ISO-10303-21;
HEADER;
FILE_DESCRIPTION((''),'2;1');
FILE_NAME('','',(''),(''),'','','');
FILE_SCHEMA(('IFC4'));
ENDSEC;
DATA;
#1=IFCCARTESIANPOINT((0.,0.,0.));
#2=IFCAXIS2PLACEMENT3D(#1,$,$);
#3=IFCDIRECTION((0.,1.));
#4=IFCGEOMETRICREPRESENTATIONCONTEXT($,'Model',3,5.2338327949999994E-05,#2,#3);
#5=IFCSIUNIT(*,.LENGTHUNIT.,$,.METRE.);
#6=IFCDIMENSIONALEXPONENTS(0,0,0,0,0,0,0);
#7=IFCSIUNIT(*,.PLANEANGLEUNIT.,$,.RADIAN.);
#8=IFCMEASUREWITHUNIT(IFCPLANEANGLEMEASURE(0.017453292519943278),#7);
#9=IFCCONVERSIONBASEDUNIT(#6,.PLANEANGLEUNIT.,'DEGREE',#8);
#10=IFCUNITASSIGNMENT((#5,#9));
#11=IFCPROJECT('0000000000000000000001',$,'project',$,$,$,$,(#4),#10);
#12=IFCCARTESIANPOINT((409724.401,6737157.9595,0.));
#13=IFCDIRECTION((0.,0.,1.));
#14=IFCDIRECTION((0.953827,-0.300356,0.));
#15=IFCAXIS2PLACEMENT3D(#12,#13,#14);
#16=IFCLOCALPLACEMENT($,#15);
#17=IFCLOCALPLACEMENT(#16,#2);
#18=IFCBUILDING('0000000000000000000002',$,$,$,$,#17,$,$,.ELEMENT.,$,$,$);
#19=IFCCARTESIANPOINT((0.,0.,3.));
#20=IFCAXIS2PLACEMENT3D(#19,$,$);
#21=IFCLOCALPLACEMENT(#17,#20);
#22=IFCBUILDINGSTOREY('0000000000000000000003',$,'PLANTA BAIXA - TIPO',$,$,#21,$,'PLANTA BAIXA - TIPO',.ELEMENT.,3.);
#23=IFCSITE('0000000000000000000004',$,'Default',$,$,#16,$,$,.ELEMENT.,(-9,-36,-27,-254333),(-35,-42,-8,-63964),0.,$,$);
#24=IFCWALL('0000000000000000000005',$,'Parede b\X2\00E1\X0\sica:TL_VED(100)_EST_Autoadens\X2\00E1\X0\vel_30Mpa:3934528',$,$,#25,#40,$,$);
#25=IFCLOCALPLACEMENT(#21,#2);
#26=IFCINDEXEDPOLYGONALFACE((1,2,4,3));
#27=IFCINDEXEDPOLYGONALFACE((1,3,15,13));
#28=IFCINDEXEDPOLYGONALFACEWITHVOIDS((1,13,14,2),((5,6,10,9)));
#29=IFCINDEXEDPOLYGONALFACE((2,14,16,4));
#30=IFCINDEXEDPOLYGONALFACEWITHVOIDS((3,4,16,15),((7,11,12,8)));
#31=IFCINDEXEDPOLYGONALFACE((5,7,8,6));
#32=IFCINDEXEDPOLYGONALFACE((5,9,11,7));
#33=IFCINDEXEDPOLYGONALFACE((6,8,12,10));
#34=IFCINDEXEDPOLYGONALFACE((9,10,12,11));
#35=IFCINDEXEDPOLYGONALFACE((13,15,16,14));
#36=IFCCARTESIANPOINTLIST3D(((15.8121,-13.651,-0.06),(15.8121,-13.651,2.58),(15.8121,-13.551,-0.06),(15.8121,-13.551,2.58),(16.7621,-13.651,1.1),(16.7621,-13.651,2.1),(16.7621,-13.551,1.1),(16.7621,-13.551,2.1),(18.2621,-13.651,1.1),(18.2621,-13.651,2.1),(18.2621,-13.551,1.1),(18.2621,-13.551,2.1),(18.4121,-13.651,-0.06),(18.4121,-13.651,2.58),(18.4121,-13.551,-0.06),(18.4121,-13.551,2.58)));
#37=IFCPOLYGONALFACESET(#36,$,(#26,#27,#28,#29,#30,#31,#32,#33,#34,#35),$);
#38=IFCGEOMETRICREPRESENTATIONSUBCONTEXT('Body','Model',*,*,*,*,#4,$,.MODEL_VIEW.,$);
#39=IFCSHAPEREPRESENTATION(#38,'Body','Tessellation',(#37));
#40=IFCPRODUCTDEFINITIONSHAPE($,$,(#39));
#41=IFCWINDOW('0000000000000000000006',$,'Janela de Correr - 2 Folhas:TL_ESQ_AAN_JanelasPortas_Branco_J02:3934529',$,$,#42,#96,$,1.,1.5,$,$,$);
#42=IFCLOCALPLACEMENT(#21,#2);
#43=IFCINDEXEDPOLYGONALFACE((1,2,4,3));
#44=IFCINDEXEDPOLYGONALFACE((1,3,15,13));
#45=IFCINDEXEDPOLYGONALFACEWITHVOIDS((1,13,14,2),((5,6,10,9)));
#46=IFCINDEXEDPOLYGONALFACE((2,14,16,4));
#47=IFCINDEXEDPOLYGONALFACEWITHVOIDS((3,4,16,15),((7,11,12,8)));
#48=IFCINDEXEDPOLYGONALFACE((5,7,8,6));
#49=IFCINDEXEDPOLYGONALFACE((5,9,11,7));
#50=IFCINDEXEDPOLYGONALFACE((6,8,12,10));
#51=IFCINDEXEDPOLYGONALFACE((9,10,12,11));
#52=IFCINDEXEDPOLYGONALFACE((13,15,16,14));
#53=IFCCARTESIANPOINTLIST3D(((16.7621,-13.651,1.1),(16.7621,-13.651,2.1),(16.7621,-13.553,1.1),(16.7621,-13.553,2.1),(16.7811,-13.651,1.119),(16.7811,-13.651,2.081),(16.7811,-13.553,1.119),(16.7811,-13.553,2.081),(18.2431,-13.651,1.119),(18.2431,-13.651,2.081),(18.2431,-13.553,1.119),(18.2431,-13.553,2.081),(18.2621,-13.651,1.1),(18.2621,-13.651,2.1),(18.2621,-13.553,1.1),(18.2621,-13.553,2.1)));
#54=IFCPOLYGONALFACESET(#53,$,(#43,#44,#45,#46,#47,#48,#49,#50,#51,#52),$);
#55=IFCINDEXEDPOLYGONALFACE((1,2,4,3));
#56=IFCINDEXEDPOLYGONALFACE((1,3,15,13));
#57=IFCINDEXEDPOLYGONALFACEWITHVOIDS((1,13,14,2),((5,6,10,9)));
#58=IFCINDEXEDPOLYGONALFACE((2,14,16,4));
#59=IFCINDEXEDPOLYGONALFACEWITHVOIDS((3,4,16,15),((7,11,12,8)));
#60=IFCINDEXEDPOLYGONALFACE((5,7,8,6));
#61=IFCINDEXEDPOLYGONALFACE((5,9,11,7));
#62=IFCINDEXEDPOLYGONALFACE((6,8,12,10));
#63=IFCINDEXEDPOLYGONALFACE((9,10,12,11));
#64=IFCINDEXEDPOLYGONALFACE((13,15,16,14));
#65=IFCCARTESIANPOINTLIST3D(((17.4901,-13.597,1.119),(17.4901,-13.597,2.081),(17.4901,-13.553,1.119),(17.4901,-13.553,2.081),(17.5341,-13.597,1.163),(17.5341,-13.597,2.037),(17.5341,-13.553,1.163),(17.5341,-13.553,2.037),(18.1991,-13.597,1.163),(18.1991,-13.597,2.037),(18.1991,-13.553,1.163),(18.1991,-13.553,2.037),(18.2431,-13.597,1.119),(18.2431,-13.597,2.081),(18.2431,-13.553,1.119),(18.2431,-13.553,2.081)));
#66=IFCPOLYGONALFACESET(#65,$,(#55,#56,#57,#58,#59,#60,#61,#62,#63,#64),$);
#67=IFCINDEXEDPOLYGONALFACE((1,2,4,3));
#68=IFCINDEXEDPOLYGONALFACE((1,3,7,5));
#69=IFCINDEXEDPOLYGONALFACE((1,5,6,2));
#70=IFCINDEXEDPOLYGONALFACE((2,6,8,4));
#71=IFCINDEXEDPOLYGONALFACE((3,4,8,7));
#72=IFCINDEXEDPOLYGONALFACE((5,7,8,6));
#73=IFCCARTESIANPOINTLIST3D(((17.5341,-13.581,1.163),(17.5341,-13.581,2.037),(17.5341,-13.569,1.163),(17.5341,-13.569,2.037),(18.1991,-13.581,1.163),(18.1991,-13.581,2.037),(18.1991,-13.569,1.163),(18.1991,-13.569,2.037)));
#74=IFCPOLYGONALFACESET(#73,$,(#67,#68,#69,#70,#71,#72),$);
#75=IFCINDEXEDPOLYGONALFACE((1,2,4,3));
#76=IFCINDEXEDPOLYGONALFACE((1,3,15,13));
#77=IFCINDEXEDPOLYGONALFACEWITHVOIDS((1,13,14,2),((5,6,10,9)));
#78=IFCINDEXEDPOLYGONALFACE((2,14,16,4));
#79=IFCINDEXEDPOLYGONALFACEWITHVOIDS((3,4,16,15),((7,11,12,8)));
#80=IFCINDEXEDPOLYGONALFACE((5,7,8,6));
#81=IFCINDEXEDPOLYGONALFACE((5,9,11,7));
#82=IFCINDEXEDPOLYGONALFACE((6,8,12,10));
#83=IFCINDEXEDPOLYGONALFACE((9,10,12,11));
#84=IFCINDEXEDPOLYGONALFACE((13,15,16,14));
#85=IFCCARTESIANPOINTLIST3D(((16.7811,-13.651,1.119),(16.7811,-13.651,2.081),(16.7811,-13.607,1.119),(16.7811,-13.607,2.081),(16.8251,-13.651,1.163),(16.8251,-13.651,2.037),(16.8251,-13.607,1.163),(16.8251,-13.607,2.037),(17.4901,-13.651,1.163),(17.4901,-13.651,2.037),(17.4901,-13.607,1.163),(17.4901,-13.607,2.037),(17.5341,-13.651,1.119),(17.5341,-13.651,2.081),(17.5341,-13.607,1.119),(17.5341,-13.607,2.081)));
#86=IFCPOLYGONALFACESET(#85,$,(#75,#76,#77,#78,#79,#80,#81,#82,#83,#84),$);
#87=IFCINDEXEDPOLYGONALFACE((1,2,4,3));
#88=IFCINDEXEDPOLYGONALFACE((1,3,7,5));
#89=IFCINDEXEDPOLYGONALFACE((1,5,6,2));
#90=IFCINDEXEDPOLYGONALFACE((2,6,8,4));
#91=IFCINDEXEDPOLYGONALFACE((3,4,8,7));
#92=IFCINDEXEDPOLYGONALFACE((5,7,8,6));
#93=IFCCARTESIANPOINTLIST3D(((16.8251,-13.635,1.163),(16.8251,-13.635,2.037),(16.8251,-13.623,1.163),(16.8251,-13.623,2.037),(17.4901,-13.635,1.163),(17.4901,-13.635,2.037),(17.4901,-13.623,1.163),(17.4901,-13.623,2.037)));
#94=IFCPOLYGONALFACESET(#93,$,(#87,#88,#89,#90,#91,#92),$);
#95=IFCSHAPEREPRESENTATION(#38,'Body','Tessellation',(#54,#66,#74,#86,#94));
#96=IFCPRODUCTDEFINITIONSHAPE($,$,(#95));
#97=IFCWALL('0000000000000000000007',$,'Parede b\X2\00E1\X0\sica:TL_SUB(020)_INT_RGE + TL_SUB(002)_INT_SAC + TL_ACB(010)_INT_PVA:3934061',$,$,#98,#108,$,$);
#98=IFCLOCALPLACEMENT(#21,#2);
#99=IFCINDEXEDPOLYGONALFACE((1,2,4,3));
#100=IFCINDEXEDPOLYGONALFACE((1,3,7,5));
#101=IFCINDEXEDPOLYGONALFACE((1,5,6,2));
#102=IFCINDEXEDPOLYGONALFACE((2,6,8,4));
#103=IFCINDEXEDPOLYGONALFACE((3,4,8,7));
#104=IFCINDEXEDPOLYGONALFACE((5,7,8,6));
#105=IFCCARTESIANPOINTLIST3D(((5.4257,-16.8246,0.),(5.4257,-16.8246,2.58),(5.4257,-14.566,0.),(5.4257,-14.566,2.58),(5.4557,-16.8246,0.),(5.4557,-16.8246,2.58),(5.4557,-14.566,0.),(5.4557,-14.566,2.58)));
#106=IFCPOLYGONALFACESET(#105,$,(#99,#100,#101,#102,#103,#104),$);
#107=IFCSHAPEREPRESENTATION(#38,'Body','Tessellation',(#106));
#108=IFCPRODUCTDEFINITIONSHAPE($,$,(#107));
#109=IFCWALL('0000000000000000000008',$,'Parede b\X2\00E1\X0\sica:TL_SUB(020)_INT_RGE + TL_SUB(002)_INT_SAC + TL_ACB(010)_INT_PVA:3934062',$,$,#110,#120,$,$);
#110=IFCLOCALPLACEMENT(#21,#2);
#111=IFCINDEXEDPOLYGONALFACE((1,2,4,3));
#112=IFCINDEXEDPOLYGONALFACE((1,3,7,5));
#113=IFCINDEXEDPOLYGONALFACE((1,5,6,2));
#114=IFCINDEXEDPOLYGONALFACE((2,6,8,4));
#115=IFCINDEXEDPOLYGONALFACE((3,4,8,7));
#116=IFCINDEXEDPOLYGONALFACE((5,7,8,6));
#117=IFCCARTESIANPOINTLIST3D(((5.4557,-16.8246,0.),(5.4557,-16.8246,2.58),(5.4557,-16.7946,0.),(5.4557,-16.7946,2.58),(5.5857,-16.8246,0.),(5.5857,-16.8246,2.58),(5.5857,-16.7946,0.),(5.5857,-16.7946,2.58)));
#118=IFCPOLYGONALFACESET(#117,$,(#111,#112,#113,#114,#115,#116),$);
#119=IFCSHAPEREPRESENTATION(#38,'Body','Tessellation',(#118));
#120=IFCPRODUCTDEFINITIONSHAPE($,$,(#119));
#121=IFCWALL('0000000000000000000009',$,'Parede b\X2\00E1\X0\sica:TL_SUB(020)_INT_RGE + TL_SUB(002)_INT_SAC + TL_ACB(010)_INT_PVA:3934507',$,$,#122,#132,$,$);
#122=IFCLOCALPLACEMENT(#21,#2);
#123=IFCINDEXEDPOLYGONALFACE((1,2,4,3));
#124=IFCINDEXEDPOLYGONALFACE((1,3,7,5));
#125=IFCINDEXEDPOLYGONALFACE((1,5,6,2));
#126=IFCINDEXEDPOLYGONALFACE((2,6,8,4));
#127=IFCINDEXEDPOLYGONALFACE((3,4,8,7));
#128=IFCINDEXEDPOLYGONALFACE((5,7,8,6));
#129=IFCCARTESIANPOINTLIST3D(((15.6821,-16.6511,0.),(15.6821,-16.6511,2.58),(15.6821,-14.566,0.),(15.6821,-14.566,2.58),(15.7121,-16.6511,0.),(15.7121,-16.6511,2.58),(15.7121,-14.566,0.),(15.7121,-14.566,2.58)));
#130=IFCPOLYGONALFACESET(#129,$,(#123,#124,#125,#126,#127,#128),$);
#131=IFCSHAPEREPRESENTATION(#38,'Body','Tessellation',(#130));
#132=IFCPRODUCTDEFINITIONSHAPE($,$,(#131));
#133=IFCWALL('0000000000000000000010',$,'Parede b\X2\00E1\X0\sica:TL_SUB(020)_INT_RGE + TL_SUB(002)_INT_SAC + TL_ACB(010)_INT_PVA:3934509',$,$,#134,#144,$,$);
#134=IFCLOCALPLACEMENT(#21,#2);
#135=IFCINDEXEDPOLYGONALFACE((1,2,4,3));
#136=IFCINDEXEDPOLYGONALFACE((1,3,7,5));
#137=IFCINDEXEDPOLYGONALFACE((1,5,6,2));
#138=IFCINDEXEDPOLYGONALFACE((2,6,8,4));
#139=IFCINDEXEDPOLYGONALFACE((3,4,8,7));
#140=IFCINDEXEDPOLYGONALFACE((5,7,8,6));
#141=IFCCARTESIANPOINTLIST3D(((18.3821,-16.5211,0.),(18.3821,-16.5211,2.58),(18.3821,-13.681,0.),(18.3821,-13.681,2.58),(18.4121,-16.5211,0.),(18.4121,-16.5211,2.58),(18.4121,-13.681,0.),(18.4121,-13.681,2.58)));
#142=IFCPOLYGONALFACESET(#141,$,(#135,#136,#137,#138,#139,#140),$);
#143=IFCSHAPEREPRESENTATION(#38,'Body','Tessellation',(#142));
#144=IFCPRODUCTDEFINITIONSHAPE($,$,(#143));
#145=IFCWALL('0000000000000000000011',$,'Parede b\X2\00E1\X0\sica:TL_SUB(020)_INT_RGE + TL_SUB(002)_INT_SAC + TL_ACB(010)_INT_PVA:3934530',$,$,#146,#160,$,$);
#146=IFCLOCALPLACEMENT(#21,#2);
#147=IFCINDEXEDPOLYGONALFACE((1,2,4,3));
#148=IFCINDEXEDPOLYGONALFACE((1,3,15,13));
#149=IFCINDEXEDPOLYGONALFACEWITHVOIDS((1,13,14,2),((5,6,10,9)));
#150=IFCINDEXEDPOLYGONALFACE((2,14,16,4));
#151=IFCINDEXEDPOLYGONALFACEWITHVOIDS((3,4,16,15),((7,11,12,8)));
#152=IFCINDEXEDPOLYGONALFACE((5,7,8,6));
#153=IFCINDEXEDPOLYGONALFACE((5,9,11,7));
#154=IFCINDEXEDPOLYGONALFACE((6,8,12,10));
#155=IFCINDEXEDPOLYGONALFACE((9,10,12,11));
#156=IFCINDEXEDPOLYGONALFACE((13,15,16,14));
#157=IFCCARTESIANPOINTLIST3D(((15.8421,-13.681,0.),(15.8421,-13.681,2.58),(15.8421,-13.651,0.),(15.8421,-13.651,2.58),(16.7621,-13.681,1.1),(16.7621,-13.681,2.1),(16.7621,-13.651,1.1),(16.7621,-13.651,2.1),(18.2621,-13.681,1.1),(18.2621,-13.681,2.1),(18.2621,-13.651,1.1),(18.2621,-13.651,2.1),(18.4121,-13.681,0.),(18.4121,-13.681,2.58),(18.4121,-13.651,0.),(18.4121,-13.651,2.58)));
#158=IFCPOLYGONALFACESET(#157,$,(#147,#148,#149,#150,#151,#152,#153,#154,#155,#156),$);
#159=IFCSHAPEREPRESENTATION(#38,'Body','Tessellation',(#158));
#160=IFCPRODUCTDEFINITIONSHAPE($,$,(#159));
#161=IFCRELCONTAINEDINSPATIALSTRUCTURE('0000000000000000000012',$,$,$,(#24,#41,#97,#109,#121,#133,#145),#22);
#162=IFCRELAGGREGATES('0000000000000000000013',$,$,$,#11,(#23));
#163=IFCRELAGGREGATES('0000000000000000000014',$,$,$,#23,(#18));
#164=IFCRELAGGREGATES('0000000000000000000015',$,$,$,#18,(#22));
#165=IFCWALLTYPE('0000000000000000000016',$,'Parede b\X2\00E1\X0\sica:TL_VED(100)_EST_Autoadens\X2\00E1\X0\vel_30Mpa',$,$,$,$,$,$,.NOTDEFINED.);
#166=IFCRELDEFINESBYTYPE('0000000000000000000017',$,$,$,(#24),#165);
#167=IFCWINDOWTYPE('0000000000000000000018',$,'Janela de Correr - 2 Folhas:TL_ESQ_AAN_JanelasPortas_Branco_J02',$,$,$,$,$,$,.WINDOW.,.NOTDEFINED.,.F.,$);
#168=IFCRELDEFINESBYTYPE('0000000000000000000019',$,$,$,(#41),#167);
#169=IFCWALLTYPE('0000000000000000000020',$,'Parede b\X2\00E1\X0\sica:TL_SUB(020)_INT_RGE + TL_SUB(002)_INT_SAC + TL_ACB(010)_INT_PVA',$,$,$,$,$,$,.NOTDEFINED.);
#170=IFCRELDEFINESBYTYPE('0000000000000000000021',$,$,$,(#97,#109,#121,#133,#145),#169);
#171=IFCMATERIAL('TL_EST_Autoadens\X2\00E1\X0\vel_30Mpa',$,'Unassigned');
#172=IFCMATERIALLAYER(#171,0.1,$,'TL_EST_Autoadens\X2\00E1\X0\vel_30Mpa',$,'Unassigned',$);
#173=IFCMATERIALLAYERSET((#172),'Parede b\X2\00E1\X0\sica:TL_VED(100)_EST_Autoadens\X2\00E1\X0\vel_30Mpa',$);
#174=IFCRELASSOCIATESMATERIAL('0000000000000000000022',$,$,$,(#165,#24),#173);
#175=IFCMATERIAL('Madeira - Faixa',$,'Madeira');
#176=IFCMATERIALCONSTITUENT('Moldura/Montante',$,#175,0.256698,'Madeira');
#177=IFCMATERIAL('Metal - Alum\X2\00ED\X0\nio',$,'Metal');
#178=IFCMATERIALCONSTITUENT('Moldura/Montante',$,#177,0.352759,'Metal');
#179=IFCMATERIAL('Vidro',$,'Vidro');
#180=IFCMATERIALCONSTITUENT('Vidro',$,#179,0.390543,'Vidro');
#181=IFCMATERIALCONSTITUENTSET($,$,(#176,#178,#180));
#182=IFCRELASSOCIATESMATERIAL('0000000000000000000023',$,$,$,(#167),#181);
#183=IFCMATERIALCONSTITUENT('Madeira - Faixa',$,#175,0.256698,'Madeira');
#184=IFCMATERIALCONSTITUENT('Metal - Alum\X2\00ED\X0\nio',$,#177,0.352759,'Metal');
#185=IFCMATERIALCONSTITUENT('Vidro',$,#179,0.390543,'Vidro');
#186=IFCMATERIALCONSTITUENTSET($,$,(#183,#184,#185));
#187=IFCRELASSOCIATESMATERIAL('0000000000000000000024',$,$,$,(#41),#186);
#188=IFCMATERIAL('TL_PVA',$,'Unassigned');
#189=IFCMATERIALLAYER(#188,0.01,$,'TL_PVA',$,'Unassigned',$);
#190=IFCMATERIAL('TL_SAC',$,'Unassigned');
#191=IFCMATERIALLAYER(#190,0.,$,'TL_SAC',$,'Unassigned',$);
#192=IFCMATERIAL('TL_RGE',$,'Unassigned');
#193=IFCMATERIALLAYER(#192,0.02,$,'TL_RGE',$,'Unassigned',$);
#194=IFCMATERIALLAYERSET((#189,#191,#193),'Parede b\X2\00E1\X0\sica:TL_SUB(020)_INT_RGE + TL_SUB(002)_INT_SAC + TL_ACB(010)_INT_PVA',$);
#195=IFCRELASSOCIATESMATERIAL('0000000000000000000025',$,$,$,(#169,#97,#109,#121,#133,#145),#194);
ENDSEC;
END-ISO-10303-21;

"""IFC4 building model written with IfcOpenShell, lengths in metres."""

from ifc_helpers import new_model, entity, si_unit, converted_unit, direction, frame, frame_2d, origin, origin_2d_with_axis, place, context, subcontext, project, spatial, polyline, rectangle, outline, extrude, source, transform, mapped, material, layer, layer_set, layer_usage, constituent, constituent_set, type_object, type_shapes, element, fill, save


model = new_model("IFC4")

# Units and contexts
model_context = context("Model", 3, precision=5.2338327949999994e-05, world=origin(), true_north=direction((0.0, 1.0)))
body_context = subcontext(model_context, "Body", "Model", "MODEL_VIEW")
ifc_project = project(units=[si_unit("LENGTHUNIT", "METRE"), converted_unit("PLANEANGLEUNIT", "DEGREE", entity("IfcPlaneAngleMeasure", 0.017453292519943278), si_unit("PLANEANGLEUNIT", "RADIAN"), dimensions=[0, 0, 0, 0, 0, 0, 0])], contexts=[model_context])

# Site, building, storey
site_placement = place(None, frame((409724.401, 6737157.9595, 0.0), z_axis=(0.0, 0.0, 1.0), x_axis=(0.953827, -0.300356, 0.0)))
site = spatial("IfcSite", under=ifc_project, at=site_placement, Name="Default", CompositionType="ELEMENT", RefLatitude=(-9, -36, -27, -254333), RefLongitude=(-35, -42, -8, -63964), RefElevation=0.0)
building_placement = place(site_placement, origin())
building = spatial("IfcBuilding", under=site, at=building_placement, CompositionType="ELEMENT")
storey_placement = place(building_placement, frame((0.0, 0.0, 3.0)))
storey = spatial("IfcBuildingStorey", under=building, at=storey_placement, Name="PLANTA BAIXA - TIPO", LongName="PLANTA BAIXA - TIPO", CompositionType="ELEMENT", Elevation=3.0)

# Shared definitions
ifc_material_1 = material(Name="TL_EST_Autoadensável_30Mpa", Category="Unassigned")
ifc_layer_1 = layer(ifc_material_1, 0.1, Name="TL_EST_Autoadensável_30Mpa", Category="Unassigned")
ifc_layer_set_1 = layer_set([ifc_layer_1], Name="Parede básica:TL_VED(100)_EST_Autoadensável_30Mpa")
wall_type_1 = type_object("IfcWallType", Name="Parede básica:TL_VED(100)_EST_Autoadensável_30Mpa", PredefinedType="NOTDEFINED", material=ifc_layer_set_1)

# Shared definitions
ifc_material_2 = material(Name="Vidro", Category="Vidro")

# Wall, opening, window
ifc_layer_usage_1 = layer_usage(ifc_layer_set_1, "AXIS2", "POSITIVE", -0.05)
wall_1_placement = place(storey_placement, frame((18.4121, -13.601, -0.06), z_axis=(0.0, 0.0, 1.0), x_axis=(-1.0, 0.0, 0.0)))
wall_1 = element("IfcWall", 1, at=wall_1_placement, inside=storey, type_object=wall_type_1, material=ifc_layer_usage_1, Name="Parede básica:TL_VED(100)_EST_Autoadensável_30Mpa:3934528", context=body_context, shape_type="SweptSolid", body=[
    extrude(rectangle(XDim=2.6, YDim=0.1, at=frame_2d((1.3, 0.0), x_axis=(-1.0, 0.0))), origin(), (0.0, 0.0, 1.0), 2.64),
])
opening_1_placement = place(wall_1_placement, frame((1.65, 0.05, 1.16)))
opening_1 = element("IfcOpeningElement", 2, at=opening_1_placement, cuts=wall_1, PredefinedType="OPENING", context=body_context, shape_type="SweptSolid", body=[
    extrude(rectangle(XDim=1.0, YDim=1.5, at=frame_2d((0.5, 0.75), x_axis=(-1.0, 0.0))), frame((0.0, 0.0, 0.0), z_axis=(0.0, -1.0, 0.0), x_axis=(0.0, 0.0, 1.0)), (0.0, 0.0, 1.0), 0.1),
])
ifc_material_3 = material(Name="Madeira - Faixa", Category="Madeira")
ifc_constituent_1 = constituent(ifc_material_3, Name="Madeira - Faixa", Category="Madeira", fraction=0.256698)
ifc_material_4 = material(Name="Metal - Alumínio", Category="Metal")
ifc_constituent_2 = constituent(ifc_material_4, Name="Metal - Alumínio", Category="Metal", fraction=0.352759)
ifc_constituent_3 = constituent(ifc_material_2, Name="Vidro", Category="Vidro", fraction=0.390543)
ifc_constituent_set_1 = constituent_set(constituents=[ifc_constituent_1, ifc_constituent_2, ifc_constituent_3])
ifc_constituent_4 = constituent(ifc_material_3, Name="Moldura/Montante", Category="Madeira", fraction=0.256698)
ifc_constituent_5 = constituent(ifc_material_4, Name="Moldura/Montante", Category="Metal", fraction=0.352759)
ifc_constituent_6 = constituent(ifc_material_2, Name="Vidro", Category="Vidro", fraction=0.390543)
ifc_constituent_set_2 = constituent_set(constituents=[ifc_constituent_4, ifc_constituent_5, ifc_constituent_6])
window_type = type_object("IfcWindowType", Name="Janela de Correr - 2 Folhas:TL_ESQ_AAN_JanelasPortas_Branco_J02", ParameterTakesPrecedence=False, PartitioningType="NOTDEFINED", PredefinedType="WINDOW", material=ifc_constituent_set_2)
shared_shape_1 = source(origin(), body_context, "Body", "SweptSolid", [
    extrude(outline(polyline([(-0.75, -0.5), (0.75, -0.5), (0.75, 0.5), (-0.75, 0.5), (-0.75, -0.5)]), holes=[polyline([(-0.731, -0.481), (-0.731, 0.481), (0.731, 0.481), (0.731, -0.481), (-0.731, -0.481)])]), frame((0.75, 0.0, 0.5), z_axis=(0.0, 1.0, 0.0), x_axis=(1.0, 0.0, 0.0)), (0.0, 0.0, 1.0), 0.098),
    extrude(outline(polyline([(-0.3765, -0.481), (0.3765, -0.481), (0.3765, 0.481), (-0.3765, 0.481), (-0.3765, -0.481)]), holes=[polyline([(-0.3325, -0.437), (-0.3325, 0.437), (0.3325, 0.437), (0.3325, -0.437), (-0.3325, -0.437)])]), frame((1.1045, 0.054, 0.5), z_axis=(0.0, 1.0, 0.0), x_axis=(1.0, 0.0, 0.0)), (0.0, 0.0, 1.0), 0.044),
    extrude(rectangle(XDim=0.012, YDim=0.665, at=origin_2d_with_axis()), frame((1.1045, 0.076, 0.063), z_axis=(0.0, 0.0, 1.0), x_axis=(0.0, -1.0, 0.0)), (0.0, 0.0, 1.0), 0.874),
    extrude(outline(polyline([(-0.481, -0.3765), (0.481, -0.3765), (0.481, 0.3765), (-0.481, 0.3765), (-0.481, -0.3765)]), holes=[polyline([(-0.437, -0.3325), (-0.437, 0.3325), (0.437, 0.3325), (0.437, -0.3325), (-0.437, -0.3325)])]), frame((0.3955, 0.0, 0.5), z_axis=(0.0, 1.0, 0.0), x_axis=(0.0, 0.0, -1.0)), (0.0, 0.0, 1.0), 0.044),
    extrude(rectangle(XDim=0.012, YDim=0.665, at=origin_2d_with_axis()), frame((0.3955, 0.022, 0.063), z_axis=(0.0, 0.0, 1.0), x_axis=(0.0, -1.0, 0.0)), (0.0, 0.0, 1.0), 0.874),
])
type_shapes(window_type, [shared_shape_1])
window_placement = place(opening_1_placement, frame((0.0, 0.0, 0.0), z_axis=(0.0, 0.0, 1.0), x_axis=(-1.0, 0.0, 0.0)))
window = element("IfcWindow", 3, at=window_placement, inside=storey, type_object=window_type, material=ifc_constituent_set_1, Name="Janela de Correr - 2 Folhas:TL_ESQ_AAN_JanelasPortas_Branco_J02:3934529", OverallHeight=1.0, OverallWidth=1.5, context=body_context, shape_type="MappedRepresentation", body=[
    mapped(shared_shape_1, transform((0.0, 0.0, 0.0), scale=1.0)),
])
fill(opening_1, window)

# Walls
ifc_material_5 = material(Name="TL_PVA", Category="Unassigned")
ifc_layer_2 = layer(ifc_material_5, 0.01, Name="TL_PVA", Category="Unassigned")
ifc_material_6 = material(Name="TL_SAC", Category="Unassigned")
ifc_layer_3 = layer(ifc_material_6, 0.0, Name="TL_SAC", Category="Unassigned")
ifc_material_7 = material(Name="TL_RGE", Category="Unassigned")
ifc_layer_4 = layer(ifc_material_7, 0.02, Name="TL_RGE", Category="Unassigned")
ifc_layer_set_2 = layer_set([ifc_layer_2, ifc_layer_3, ifc_layer_4], Name="Parede básica:TL_SUB(020)_INT_RGE + TL_SUB(002)_INT_SAC + TL_ACB(010)_INT_PVA")
ifc_layer_usage_2 = layer_usage(ifc_layer_set_2, "AXIS2", "NEGATIVE", 0.015)
wall_type_2 = type_object("IfcWallType", Name="Parede básica:TL_SUB(020)_INT_RGE + TL_SUB(002)_INT_SAC + TL_ACB(010)_INT_PVA", PredefinedType="NOTDEFINED", material=ifc_layer_set_2)
wall_2_placement = place(storey_placement, frame((5.4407, -16.8246, 0.0), z_axis=(0.0, 0.0, 1.0), x_axis=(0.0, 1.0, 0.0)))
element("IfcWall", 4, at=wall_2_placement, inside=storey, type_object=wall_type_2, material=ifc_layer_usage_2, Name="Parede básica:TL_SUB(020)_INT_RGE + TL_SUB(002)_INT_SAC + TL_ACB(010)_INT_PVA:3934061", context=body_context, shape_type="SweptSolid", body=[
    extrude(rectangle(XDim=2.2587, YDim=0.03, at=frame_2d((1.1293, 0.0), x_axis=(-1.0, 0.0))), origin(), (0.0, 0.0, 1.0), 2.58),
])
ifc_layer_usage_3 = layer_usage(ifc_layer_set_2, "AXIS2", "NEGATIVE", 0.015)
wall_3_placement = place(storey_placement, frame((5.5857, -16.8096, 0.0), z_axis=(0.0, 0.0, 1.0), x_axis=(-1.0, 0.0, 0.0)))
element("IfcWall", 5, at=wall_3_placement, inside=storey, type_object=wall_type_2, material=ifc_layer_usage_3, Name="Parede básica:TL_SUB(020)_INT_RGE + TL_SUB(002)_INT_SAC + TL_ACB(010)_INT_PVA:3934062", context=body_context, shape_type="SweptSolid", body=[
    extrude(rectangle(XDim=0.13, YDim=0.03, at=frame_2d((0.065, 0.0), x_axis=(-1.0, 0.0))), origin(), (0.0, 0.0, 1.0), 2.58),
])
ifc_layer_usage_4 = layer_usage(ifc_layer_set_2, "AXIS2", "POSITIVE", -0.015)
wall_4_placement = place(storey_placement, frame((15.6971, -14.566, 0.0), z_axis=(0.0, 0.0, 1.0), x_axis=(0.0, -1.0, 0.0)))
element("IfcWall", 6, at=wall_4_placement, inside=storey, type_object=wall_type_2, material=ifc_layer_usage_4, Name="Parede básica:TL_SUB(020)_INT_RGE + TL_SUB(002)_INT_SAC + TL_ACB(010)_INT_PVA:3934507", context=body_context, shape_type="SweptSolid", body=[
    extrude(rectangle(XDim=2.0851, YDim=0.03, at=frame_2d((1.0426, 0.0), x_axis=(-1.0, 0.0))), origin(), (0.0, 0.0, 1.0), 2.58),
])
ifc_layer_usage_5 = layer_usage(ifc_layer_set_2, "AXIS2", "POSITIVE", -0.015)
wall_5_placement = place(storey_placement, frame((18.3971, -13.681, 0.0), z_axis=(0.0, 0.0, 1.0), x_axis=(0.0, -1.0, 0.0)))
element("IfcWall", 7, at=wall_5_placement, inside=storey, type_object=wall_type_2, material=ifc_layer_usage_5, Name="Parede básica:TL_SUB(020)_INT_RGE + TL_SUB(002)_INT_SAC + TL_ACB(010)_INT_PVA:3934509", context=body_context, shape_type="SweptSolid", body=[
    extrude(rectangle(XDim=2.8401, YDim=0.03, at=frame_2d((1.4201, 0.0), x_axis=(-1.0, 0.0))), origin(), (0.0, 0.0, 1.0), 2.58),
])

# Wall, opening
ifc_layer_usage_6 = layer_usage(ifc_layer_set_2, "AXIS2", "POSITIVE", -0.015)
wall_6_placement = place(storey_placement, frame((15.8421, -13.666, 0.0)))
wall_6 = element("IfcWall", 8, at=wall_6_placement, inside=storey, type_object=wall_type_2, material=ifc_layer_usage_6, Name="Parede básica:TL_SUB(020)_INT_RGE + TL_SUB(002)_INT_SAC + TL_ACB(010)_INT_PVA:3934530", context=body_context, shape_type="SweptSolid", body=[
    extrude(rectangle(XDim=2.57, YDim=0.03, at=frame_2d((1.285, 0.0), x_axis=(-1.0, 0.0))), origin(), (0.0, 0.0, 1.0), 2.58),
])
opening_2_placement = place(wall_6_placement, frame((-15.8421, 13.666, 1.1)))
element("IfcOpeningElement", 9, at=opening_2_placement, cuts=wall_6, PredefinedType="OPENING", context=body_context, shape_type="SweptSolid", body=[
    extrude(rectangle(XDim=1.0, YDim=1.5, at=frame_2d((0.0, 0.0), x_axis=(0.0, 1.0))), frame((17.5121, -15.175, 0.5), z_axis=(0.0, 1.0, 0.0), x_axis=(1.0, 0.0, 0.0)), (0.0, 0.0, 1.0), 3.048),
])

save(model, "model.ifc")
